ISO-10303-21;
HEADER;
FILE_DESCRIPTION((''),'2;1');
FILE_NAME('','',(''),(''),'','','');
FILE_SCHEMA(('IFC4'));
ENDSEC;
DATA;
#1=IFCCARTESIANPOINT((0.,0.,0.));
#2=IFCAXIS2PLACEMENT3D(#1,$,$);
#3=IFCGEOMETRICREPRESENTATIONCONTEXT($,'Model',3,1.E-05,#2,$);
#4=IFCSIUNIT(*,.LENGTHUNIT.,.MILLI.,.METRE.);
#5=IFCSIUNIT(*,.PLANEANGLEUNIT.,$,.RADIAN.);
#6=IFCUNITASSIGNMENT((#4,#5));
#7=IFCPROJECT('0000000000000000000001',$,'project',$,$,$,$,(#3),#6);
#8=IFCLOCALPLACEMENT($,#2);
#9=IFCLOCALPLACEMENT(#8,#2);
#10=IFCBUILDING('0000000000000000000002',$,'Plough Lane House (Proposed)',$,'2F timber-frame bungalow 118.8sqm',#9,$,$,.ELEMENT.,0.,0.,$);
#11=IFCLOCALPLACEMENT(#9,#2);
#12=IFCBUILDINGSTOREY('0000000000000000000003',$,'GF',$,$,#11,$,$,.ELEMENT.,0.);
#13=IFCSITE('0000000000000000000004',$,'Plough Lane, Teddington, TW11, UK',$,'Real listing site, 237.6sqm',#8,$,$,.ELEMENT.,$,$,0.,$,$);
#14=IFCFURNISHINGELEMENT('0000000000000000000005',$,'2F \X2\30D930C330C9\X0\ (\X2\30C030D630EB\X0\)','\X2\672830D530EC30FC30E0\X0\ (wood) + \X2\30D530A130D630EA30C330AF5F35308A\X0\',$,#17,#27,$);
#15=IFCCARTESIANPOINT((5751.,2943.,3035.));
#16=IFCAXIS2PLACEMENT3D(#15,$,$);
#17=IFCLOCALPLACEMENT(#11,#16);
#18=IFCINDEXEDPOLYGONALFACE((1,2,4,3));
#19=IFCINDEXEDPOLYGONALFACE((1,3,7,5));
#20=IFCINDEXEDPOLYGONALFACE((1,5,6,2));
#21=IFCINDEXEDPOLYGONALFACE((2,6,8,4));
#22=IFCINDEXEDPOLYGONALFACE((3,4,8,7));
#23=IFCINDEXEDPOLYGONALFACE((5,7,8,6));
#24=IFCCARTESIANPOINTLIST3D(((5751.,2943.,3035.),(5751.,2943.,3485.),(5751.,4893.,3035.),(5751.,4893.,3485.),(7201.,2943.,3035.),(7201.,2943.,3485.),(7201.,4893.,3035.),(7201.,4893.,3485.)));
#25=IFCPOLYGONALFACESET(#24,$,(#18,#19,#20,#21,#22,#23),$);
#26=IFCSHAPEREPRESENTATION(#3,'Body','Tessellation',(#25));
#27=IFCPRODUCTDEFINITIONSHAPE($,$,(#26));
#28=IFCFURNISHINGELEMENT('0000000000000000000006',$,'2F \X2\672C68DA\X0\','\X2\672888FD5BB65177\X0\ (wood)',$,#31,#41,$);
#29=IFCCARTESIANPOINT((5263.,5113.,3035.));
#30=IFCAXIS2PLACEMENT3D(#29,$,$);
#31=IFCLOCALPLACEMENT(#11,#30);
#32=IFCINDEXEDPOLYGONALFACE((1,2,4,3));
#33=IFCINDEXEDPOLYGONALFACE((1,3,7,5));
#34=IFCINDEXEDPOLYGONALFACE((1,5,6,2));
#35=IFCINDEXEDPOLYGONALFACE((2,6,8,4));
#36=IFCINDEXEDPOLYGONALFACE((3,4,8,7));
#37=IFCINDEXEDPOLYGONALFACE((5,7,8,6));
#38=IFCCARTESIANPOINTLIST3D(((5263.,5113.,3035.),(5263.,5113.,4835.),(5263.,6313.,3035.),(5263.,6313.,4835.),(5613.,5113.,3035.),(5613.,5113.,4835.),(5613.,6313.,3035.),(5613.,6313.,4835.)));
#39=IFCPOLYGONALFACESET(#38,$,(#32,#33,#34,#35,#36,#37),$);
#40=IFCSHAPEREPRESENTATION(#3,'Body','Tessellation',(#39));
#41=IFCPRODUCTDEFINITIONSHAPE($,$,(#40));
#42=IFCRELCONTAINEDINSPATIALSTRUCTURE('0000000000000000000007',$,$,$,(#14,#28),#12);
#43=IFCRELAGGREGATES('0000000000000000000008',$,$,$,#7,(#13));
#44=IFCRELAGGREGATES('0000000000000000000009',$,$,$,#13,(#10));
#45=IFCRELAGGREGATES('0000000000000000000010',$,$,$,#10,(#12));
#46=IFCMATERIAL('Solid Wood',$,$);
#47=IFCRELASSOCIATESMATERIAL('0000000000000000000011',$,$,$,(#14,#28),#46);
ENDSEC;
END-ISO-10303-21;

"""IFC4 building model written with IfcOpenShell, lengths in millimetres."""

from ifc_helpers import new_model, si_unit, frame, frame_2d, origin, place, context, project, spatial, rectangle, extrude, material, element, save


model = new_model("IFC4")

# Units and contexts
model_context = context("Model", 3, precision=1e-05, world=origin())
ifc_project = project(units=[si_unit("LENGTHUNIT", "METRE", prefix="MILLI"), si_unit("PLANEANGLEUNIT", "RADIAN")], contexts=[model_context])

# Site, building, storey
site_placement = place(None, origin())
site = spatial("IfcSite", under=ifc_project, at=site_placement, Name="Plough Lane, Teddington, TW11, UK", ObjectType="Real listing site, 237.6sqm", CompositionType="ELEMENT", RefElevation=0.0)
building_placement = place(site_placement, origin())
building = spatial("IfcBuilding", under=site, at=building_placement, Name="Plough Lane House (Proposed)", ObjectType="2F timber-frame bungalow 118.8sqm", CompositionType="ELEMENT", ElevationOfRefHeight=0.0, ElevationOfTerrain=0.0)
storey_placement = place(building_placement, origin())
storey = spatial("IfcBuildingStorey", under=building, at=storey_placement, Name="GF", CompositionType="ELEMENT", Elevation=0.0)

# Shared definitions
ifc_material_1 = material(Name="Solid Wood")

# Furnishing elements
furnishing_1_placement = place(storey_placement, frame((5751.0, 2943.0, 3035.0)))
element("IfcFurnishingElement", 1, at=furnishing_1_placement, inside=storey, material=ifc_material_1, Name="2F ベッド (ダブル)", Description="木フレーム (wood) + ファブリック張り", context=model_context, shape_type="SweptSolid", body=[
    extrude(rectangle(XDim=1450.0, YDim=1950.0, at=frame_2d((725.0, 975.0))), frame((5751.0, 2943.0, 3035.0)), (0.0, 0.0, 1.0), 450.0),
])
furnishing_2_placement = place(storey_placement, frame((5263.0, 5113.0, 3035.0)))
element("IfcFurnishingElement", 2, at=furnishing_2_placement, inside=storey, material=ifc_material_1, Name="2F 本棚", Description="木製家具 (wood)", context=model_context, shape_type="SweptSolid", body=[
    extrude(rectangle(XDim=350.0, YDim=1200.0, at=frame_2d((175.0, 600.0))), frame((5263.0, 5113.0, 3035.0)), (0.0, 0.0, 1.0), 1800.0),
])

save(model, "model.ifc")
